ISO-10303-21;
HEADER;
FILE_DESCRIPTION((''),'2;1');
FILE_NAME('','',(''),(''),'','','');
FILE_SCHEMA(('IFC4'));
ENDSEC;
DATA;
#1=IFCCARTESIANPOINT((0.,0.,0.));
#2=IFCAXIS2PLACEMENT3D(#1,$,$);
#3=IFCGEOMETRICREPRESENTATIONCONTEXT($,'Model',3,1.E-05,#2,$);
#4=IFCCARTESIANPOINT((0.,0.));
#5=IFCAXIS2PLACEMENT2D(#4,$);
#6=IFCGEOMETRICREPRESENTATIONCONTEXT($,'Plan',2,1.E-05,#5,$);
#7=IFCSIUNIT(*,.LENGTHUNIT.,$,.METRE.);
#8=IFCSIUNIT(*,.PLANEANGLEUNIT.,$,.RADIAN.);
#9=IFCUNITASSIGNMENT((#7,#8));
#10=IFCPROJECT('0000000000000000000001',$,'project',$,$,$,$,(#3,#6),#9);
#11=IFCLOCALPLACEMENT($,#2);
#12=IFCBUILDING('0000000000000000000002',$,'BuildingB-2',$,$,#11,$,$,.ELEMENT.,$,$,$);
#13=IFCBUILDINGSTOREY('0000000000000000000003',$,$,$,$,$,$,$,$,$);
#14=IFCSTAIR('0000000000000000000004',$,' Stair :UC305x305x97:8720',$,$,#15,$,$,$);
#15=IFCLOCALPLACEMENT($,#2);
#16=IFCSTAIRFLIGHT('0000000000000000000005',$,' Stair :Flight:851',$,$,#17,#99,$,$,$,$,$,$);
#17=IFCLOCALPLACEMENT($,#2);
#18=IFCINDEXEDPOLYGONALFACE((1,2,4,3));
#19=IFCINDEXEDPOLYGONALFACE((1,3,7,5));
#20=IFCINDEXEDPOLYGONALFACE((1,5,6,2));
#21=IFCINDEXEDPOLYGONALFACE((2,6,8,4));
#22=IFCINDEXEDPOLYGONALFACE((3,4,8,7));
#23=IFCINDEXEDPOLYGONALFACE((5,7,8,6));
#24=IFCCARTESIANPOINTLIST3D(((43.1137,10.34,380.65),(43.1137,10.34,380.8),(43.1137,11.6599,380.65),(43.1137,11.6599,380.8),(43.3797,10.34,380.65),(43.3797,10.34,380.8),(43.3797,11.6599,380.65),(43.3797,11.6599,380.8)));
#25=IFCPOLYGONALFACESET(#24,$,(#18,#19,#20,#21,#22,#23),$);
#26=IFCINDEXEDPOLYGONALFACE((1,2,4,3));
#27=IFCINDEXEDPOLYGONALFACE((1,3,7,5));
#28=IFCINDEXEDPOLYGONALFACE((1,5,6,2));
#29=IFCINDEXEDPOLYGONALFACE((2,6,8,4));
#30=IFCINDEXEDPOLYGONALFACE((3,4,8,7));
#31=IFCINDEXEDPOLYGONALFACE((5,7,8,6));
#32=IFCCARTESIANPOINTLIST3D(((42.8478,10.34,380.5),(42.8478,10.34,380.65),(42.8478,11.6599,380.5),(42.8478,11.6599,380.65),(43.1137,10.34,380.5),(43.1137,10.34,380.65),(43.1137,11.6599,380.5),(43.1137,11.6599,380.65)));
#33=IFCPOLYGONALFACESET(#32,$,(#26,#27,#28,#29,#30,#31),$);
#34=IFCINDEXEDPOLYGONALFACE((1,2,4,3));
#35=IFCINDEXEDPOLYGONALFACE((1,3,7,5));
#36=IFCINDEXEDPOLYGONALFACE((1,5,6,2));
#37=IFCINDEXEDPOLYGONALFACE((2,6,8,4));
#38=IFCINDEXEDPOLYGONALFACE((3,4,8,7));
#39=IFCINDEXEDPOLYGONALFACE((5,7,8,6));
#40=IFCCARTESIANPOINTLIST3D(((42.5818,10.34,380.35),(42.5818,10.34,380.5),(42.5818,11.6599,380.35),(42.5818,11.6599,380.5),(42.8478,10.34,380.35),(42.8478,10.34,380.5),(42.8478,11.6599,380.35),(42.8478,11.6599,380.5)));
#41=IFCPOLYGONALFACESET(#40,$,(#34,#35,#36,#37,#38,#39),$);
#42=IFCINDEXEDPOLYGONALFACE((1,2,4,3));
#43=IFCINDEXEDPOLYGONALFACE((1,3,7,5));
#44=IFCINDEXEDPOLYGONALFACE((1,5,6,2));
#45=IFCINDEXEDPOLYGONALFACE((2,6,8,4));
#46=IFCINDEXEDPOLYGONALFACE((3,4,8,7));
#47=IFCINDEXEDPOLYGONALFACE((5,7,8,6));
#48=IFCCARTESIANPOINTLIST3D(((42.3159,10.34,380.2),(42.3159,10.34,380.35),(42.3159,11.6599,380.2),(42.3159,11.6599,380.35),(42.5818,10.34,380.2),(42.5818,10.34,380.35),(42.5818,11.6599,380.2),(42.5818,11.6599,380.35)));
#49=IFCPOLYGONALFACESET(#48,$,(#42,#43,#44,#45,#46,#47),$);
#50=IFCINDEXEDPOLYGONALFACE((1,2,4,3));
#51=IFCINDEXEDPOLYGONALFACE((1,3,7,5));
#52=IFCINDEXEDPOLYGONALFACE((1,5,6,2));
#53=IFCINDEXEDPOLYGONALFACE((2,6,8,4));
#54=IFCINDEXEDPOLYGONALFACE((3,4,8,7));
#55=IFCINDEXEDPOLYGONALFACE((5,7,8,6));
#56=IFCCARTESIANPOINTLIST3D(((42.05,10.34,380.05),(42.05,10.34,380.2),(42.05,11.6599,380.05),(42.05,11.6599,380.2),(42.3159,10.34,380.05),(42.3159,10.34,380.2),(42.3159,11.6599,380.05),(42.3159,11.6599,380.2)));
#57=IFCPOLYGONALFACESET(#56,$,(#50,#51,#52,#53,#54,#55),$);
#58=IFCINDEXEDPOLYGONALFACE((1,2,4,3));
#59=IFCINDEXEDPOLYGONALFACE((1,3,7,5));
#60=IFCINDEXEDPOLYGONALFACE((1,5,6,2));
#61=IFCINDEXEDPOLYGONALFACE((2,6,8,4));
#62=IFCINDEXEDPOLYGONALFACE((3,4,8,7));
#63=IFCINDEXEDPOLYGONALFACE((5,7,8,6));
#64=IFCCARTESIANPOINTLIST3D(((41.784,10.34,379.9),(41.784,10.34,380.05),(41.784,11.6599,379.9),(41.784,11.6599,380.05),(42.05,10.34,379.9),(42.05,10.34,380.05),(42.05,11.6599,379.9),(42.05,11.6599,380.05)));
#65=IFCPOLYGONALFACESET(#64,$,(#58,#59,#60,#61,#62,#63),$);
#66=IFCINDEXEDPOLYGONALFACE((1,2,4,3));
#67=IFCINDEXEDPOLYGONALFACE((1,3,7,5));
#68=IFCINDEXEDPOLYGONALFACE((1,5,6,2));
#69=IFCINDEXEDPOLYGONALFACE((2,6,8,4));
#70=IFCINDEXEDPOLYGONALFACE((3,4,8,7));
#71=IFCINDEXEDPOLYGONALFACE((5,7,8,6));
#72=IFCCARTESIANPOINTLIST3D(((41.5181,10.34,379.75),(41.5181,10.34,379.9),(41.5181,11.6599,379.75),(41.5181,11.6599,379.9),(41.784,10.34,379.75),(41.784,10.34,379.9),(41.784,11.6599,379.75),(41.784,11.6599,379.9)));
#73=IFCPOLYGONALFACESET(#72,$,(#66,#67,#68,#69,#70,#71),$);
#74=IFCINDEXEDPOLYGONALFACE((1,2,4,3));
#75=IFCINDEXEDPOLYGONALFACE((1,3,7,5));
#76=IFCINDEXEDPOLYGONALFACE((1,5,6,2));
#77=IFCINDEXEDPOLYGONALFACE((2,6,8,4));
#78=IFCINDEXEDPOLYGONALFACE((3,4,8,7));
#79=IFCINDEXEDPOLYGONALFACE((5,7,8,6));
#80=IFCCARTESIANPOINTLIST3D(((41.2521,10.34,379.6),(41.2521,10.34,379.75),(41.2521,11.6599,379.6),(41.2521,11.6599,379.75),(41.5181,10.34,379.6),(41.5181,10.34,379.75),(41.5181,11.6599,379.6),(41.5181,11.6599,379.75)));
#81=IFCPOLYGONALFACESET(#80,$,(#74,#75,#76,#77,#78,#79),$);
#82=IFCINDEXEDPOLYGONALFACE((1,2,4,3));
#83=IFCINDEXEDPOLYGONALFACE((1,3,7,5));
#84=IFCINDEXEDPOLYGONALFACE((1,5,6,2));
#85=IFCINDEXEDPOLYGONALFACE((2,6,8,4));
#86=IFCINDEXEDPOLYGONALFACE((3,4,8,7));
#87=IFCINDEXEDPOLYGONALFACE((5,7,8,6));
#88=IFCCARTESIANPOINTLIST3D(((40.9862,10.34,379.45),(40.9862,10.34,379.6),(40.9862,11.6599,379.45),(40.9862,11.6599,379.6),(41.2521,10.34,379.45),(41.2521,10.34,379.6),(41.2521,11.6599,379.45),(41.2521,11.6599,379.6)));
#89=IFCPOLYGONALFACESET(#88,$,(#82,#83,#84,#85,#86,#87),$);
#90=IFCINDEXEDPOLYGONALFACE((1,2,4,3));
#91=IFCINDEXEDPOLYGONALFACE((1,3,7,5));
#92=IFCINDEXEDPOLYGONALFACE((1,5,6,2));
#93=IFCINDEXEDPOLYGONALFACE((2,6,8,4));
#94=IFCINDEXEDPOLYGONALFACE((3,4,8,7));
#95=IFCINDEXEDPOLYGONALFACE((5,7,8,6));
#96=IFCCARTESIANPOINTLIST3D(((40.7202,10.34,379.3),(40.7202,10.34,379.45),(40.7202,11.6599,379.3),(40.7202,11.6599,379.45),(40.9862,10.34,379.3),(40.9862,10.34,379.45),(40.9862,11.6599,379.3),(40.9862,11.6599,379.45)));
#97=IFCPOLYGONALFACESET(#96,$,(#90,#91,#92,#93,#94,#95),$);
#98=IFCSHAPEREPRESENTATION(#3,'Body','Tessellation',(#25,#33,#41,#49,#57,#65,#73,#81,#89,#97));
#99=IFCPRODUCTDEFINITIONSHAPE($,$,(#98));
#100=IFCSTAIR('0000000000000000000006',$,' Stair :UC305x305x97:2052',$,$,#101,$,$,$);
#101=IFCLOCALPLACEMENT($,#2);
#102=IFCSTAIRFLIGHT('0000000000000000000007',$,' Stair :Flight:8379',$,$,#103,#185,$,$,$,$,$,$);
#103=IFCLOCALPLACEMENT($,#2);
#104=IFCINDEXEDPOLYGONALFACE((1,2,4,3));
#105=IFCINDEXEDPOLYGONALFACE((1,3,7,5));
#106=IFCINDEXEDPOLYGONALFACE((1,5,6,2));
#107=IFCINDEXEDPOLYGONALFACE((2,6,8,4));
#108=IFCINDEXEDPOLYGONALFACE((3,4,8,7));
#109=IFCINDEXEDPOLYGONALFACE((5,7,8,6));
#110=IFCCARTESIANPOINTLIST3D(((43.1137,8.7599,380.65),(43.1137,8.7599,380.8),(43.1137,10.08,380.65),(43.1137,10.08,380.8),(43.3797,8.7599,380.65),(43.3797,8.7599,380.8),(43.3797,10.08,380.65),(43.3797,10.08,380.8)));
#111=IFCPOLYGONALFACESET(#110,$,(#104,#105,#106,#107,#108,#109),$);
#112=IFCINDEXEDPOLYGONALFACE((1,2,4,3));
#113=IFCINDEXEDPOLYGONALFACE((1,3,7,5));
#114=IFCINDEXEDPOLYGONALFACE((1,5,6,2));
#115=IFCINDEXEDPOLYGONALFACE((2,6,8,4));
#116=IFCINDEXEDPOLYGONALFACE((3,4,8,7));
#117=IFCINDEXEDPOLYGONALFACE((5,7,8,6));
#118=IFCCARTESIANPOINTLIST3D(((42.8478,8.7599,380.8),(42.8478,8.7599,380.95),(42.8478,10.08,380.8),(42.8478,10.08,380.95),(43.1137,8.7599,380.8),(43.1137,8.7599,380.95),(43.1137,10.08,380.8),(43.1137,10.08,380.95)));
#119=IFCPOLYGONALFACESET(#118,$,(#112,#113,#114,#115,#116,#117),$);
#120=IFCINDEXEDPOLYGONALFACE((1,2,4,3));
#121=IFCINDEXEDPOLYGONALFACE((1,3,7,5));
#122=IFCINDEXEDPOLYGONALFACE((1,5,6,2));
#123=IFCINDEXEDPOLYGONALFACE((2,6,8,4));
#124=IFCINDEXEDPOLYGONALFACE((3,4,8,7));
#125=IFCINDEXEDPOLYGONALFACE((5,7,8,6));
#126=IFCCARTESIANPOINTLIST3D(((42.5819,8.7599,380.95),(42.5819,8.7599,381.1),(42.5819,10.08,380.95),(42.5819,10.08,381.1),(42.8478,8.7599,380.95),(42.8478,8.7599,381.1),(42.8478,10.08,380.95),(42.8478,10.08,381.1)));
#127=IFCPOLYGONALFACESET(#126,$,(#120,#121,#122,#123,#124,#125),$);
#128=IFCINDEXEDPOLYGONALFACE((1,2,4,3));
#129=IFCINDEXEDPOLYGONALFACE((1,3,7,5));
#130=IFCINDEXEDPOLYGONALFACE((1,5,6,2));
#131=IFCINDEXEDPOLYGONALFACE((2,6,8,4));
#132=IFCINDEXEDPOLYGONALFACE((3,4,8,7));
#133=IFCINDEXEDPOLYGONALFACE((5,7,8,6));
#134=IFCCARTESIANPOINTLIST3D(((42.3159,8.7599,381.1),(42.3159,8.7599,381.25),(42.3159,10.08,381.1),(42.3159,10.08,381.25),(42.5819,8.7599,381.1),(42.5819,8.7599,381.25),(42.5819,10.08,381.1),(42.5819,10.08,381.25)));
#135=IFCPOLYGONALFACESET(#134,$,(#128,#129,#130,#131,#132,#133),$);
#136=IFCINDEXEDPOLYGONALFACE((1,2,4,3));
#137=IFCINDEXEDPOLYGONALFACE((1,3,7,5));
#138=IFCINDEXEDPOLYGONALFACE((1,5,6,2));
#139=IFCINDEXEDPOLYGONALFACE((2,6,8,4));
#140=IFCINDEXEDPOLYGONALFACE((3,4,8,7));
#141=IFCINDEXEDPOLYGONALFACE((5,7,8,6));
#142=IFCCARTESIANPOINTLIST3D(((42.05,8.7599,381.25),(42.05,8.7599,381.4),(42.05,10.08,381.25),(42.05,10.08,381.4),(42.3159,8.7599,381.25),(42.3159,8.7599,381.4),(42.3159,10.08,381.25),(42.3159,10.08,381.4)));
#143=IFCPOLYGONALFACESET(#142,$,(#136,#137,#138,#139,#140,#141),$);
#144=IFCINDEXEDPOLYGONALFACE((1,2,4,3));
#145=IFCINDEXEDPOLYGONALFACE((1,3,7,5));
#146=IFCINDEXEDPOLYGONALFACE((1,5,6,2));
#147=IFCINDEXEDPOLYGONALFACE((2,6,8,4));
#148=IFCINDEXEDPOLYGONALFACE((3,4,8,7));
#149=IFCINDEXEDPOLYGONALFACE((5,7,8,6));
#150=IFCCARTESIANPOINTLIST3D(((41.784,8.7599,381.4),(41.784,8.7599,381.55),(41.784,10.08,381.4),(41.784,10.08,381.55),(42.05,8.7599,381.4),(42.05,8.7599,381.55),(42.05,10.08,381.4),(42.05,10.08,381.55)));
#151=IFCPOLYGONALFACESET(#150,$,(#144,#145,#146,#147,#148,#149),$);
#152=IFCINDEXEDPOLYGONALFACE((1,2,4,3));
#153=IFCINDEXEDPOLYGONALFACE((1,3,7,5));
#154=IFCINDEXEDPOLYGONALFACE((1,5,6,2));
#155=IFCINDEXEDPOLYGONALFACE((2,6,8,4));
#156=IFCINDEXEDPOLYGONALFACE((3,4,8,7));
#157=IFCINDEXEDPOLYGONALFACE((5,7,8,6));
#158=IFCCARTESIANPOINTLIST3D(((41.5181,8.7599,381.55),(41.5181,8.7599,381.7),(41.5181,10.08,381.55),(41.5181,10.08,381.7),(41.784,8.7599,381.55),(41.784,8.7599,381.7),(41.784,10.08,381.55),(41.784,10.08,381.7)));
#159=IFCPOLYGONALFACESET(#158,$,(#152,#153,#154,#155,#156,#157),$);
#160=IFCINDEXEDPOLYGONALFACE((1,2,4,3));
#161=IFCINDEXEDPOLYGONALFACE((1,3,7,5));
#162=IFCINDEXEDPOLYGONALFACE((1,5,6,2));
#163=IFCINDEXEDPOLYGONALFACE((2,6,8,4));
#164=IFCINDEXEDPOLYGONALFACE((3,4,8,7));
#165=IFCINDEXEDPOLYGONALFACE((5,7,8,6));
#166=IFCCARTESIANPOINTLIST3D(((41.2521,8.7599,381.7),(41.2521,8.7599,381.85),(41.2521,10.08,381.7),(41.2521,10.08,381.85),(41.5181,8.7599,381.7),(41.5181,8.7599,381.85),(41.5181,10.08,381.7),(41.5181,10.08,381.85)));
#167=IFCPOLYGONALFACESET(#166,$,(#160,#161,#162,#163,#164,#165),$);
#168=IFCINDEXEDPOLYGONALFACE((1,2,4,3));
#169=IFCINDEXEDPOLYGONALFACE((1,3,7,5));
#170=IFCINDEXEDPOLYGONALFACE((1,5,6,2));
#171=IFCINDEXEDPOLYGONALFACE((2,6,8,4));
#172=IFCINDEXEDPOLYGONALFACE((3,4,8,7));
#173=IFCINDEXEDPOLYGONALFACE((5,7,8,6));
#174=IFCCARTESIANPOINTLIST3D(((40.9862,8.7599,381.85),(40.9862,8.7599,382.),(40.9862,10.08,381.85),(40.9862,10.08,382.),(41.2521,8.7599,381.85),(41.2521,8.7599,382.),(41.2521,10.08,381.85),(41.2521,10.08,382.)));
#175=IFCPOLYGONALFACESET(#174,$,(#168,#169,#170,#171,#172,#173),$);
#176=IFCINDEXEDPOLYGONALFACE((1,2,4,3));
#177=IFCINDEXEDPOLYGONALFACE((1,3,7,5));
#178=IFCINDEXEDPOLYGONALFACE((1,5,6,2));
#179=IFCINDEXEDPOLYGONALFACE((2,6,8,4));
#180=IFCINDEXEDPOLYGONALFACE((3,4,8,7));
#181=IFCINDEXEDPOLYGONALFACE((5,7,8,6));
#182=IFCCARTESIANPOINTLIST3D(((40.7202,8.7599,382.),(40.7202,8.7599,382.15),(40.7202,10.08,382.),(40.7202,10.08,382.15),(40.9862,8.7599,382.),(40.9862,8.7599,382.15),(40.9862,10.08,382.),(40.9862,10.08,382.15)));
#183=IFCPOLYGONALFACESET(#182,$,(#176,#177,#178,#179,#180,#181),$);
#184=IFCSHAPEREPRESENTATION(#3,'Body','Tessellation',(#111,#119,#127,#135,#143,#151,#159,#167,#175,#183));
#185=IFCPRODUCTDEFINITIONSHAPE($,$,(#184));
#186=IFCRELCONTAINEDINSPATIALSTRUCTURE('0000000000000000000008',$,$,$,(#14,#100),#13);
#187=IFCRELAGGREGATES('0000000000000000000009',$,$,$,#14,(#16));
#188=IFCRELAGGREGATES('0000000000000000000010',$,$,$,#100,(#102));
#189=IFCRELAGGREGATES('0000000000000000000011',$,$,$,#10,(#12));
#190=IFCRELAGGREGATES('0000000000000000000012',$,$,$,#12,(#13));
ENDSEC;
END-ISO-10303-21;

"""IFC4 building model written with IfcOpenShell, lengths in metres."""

from ifc_helpers import new_model, si_unit, frame, origin, origin_2d, place, context, project, spatial, polyline, outline, extrude, element, aggregate, save


model = new_model("IFC4")

# Units and contexts
model_context = context("Model", 3, precision=1e-05, world=origin())
plan_context = context("Plan", 2, precision=1e-05, world=origin_2d())
ifc_project = project(units=[si_unit("LENGTHUNIT", "METRE"), si_unit("PLANEANGLEUNIT", "RADIAN")], contexts=[model_context, plan_context])

# Building, storey
building_placement = place(None, origin())
building = spatial("IfcBuilding", under=ifc_project, at=building_placement, Name="BuildingB-2", CompositionType="ELEMENT")
storey = spatial("IfcBuildingStorey", under=building)

# Stairs, stair flights
stair_1 = element("IfcStair", 1, inside=storey, Name=" Stair :UC305x305x97:8720")
stair_flight_1 = element("IfcStairFlight", 2, Name=" Stair :Flight:851", context=model_context, shape_type="SweptSolid", body=[
    extrude(outline(polyline([(43.1137, 11.6599, 380.8), (43.1137, 10.34, 380.8), (43.3797, 10.34, 380.8), (43.3797, 11.6599, 380.8), (43.1137, 11.6599, 380.8)])), origin(), (0.0, 0.0, -1.0), 0.15),
    extrude(outline(polyline([(42.8478, 11.6599, 380.8), (42.8478, 10.34, 380.8), (43.1137, 10.34, 380.8), (43.1137, 11.6599, 380.8), (42.8478, 11.6599, 380.8)])), frame((0.0, 0.0, -0.15)), (0.0, 0.0, -1.0), 0.15),
    extrude(outline(polyline([(42.5818, 11.6599, 380.8), (42.5818, 10.34, 380.8), (42.8478, 10.34, 380.8), (42.8478, 11.6599, 380.8), (42.5818, 11.6599, 380.8)])), frame((0.0, 0.0, -0.3)), (0.0, 0.0, -1.0), 0.15),
    extrude(outline(polyline([(42.3159, 11.6599, 380.8), (42.3159, 10.34, 380.8), (42.5818, 10.34, 380.8), (42.5818, 11.6599, 380.8), (42.3159, 11.6599, 380.8)])), frame((0.0, 0.0, -0.45)), (0.0, 0.0, -1.0), 0.15),
    extrude(outline(polyline([(42.05, 11.6599, 380.8), (42.05, 10.34, 380.8), (42.3159, 10.34, 380.8), (42.3159, 11.6599, 380.8), (42.05, 11.6599, 380.8)])), frame((0.0, 0.0, -0.6)), (0.0, 0.0, -1.0), 0.15),
    extrude(outline(polyline([(41.784, 11.6599, 380.8), (41.784, 10.34, 380.8), (42.05, 10.34, 380.8), (42.05, 11.6599, 380.8), (41.784, 11.6599, 380.8)])), frame((0.0, 0.0, -0.75)), (0.0, 0.0, -1.0), 0.15),
    extrude(outline(polyline([(41.5181, 11.6599, 380.8), (41.5181, 10.34, 380.8), (41.784, 10.34, 380.8), (41.784, 11.6599, 380.8), (41.5181, 11.6599, 380.8)])), frame((0.0, 0.0, -0.9)), (0.0, 0.0, -1.0), 0.15),
    extrude(outline(polyline([(41.2521, 11.6599, 380.8), (41.2521, 10.34, 380.8), (41.5181, 10.34, 380.8), (41.5181, 11.6599, 380.8), (41.2521, 11.6599, 380.8)])), frame((0.0, 0.0, -1.05)), (0.0, 0.0, -1.0), 0.15),
    extrude(outline(polyline([(40.9862, 11.6599, 380.8), (40.9862, 10.34, 380.8), (41.2521, 10.34, 380.8), (41.2521, 11.6599, 380.8), (40.9862, 11.6599, 380.8)])), frame((0.0, 0.0, -1.2)), (0.0, 0.0, -1.0), 0.15),
    extrude(outline(polyline([(40.7202, 11.6599, 380.8), (40.7202, 10.34, 380.8), (40.9862, 10.34, 380.8), (40.9862, 11.6599, 380.8), (40.7202, 11.6599, 380.8)])), frame((0.0, 0.0, -1.35)), (0.0, 0.0, -1.0), 0.15),
])
aggregate(stair_1, [stair_flight_1])
stair_2 = element("IfcStair", 3, inside=storey, Name=" Stair :UC305x305x97:2052")
stair_flight_2 = element("IfcStairFlight", 4, Name=" Stair :Flight:8379", context=model_context, shape_type="SweptSolid", body=[
    extrude(outline(polyline([(43.1137, 8.7599, 380.8), (43.1137, 10.08, 380.8), (43.3797, 10.08, 380.8), (43.3797, 8.7599, 380.8), (43.1137, 8.7599, 380.8)])), origin(), (0.0, 0.0, -1.0), 0.15),
    extrude(outline(polyline([(42.8478, 8.7599, 380.8), (42.8478, 10.08, 380.8), (43.1137, 10.08, 380.8), (43.1137, 8.7599, 380.8), (42.8478, 8.7599, 380.8)])), frame((0.0, 0.0, 0.15)), (0.0, 0.0, -1.0), 0.15),
    extrude(outline(polyline([(42.5819, 8.7599, 380.8), (42.5819, 10.08, 380.8), (42.8478, 10.08, 380.8), (42.8478, 8.7599, 380.8), (42.5819, 8.7599, 380.8)])), frame((0.0, 0.0, 0.3)), (0.0, 0.0, -1.0), 0.15),
    extrude(outline(polyline([(42.3159, 8.7599, 380.8), (42.3159, 10.08, 380.8), (42.5819, 10.08, 380.8), (42.5819, 8.7599, 380.8), (42.3159, 8.7599, 380.8)])), frame((0.0, 0.0, 0.45)), (0.0, 0.0, -1.0), 0.15),
    extrude(outline(polyline([(42.05, 8.7599, 380.8), (42.05, 10.08, 380.8), (42.3159, 10.08, 380.8), (42.3159, 8.7599, 380.8), (42.05, 8.7599, 380.8)])), frame((0.0, 0.0, 0.6)), (0.0, 0.0, -1.0), 0.15),
    extrude(outline(polyline([(41.784, 8.7599, 380.8), (41.784, 10.08, 380.8), (42.05, 10.08, 380.8), (42.05, 8.7599, 380.8), (41.784, 8.7599, 380.8)])), frame((0.0, 0.0, 0.75)), (0.0, 0.0, -1.0), 0.15),
    extrude(outline(polyline([(41.5181, 8.7599, 380.8), (41.5181, 10.08, 380.8), (41.784, 10.08, 380.8), (41.784, 8.7599, 380.8), (41.5181, 8.7599, 380.8)])), frame((0.0, 0.0, 0.9)), (0.0, 0.0, -1.0), 0.15),
    extrude(outline(polyline([(41.2521, 8.7599, 380.8), (41.2521, 10.08, 380.8), (41.5181, 10.08, 380.8), (41.5181, 8.7599, 380.8), (41.2521, 8.7599, 380.8)])), frame((0.0, 0.0, 1.05)), (0.0, 0.0, -1.0), 0.15),
    extrude(outline(polyline([(40.9862, 8.7599, 380.8), (40.9862, 10.08, 380.8), (41.2521, 10.08, 380.8), (41.2521, 8.7599, 380.8), (40.9862, 8.7599, 380.8)])), frame((0.0, 0.0, 1.2)), (0.0, 0.0, -1.0), 0.15),
    extrude(outline(polyline([(40.7202, 8.7599, 380.8), (40.7202, 10.08, 380.8), (40.9862, 10.08, 380.8), (40.9862, 8.7599, 380.8), (40.7202, 8.7599, 380.8)])), frame((0.0, 0.0, 1.35)), (0.0, 0.0, -1.0), 0.15),
])
aggregate(stair_2, [stair_flight_2])

save(model, "model.ifc")
